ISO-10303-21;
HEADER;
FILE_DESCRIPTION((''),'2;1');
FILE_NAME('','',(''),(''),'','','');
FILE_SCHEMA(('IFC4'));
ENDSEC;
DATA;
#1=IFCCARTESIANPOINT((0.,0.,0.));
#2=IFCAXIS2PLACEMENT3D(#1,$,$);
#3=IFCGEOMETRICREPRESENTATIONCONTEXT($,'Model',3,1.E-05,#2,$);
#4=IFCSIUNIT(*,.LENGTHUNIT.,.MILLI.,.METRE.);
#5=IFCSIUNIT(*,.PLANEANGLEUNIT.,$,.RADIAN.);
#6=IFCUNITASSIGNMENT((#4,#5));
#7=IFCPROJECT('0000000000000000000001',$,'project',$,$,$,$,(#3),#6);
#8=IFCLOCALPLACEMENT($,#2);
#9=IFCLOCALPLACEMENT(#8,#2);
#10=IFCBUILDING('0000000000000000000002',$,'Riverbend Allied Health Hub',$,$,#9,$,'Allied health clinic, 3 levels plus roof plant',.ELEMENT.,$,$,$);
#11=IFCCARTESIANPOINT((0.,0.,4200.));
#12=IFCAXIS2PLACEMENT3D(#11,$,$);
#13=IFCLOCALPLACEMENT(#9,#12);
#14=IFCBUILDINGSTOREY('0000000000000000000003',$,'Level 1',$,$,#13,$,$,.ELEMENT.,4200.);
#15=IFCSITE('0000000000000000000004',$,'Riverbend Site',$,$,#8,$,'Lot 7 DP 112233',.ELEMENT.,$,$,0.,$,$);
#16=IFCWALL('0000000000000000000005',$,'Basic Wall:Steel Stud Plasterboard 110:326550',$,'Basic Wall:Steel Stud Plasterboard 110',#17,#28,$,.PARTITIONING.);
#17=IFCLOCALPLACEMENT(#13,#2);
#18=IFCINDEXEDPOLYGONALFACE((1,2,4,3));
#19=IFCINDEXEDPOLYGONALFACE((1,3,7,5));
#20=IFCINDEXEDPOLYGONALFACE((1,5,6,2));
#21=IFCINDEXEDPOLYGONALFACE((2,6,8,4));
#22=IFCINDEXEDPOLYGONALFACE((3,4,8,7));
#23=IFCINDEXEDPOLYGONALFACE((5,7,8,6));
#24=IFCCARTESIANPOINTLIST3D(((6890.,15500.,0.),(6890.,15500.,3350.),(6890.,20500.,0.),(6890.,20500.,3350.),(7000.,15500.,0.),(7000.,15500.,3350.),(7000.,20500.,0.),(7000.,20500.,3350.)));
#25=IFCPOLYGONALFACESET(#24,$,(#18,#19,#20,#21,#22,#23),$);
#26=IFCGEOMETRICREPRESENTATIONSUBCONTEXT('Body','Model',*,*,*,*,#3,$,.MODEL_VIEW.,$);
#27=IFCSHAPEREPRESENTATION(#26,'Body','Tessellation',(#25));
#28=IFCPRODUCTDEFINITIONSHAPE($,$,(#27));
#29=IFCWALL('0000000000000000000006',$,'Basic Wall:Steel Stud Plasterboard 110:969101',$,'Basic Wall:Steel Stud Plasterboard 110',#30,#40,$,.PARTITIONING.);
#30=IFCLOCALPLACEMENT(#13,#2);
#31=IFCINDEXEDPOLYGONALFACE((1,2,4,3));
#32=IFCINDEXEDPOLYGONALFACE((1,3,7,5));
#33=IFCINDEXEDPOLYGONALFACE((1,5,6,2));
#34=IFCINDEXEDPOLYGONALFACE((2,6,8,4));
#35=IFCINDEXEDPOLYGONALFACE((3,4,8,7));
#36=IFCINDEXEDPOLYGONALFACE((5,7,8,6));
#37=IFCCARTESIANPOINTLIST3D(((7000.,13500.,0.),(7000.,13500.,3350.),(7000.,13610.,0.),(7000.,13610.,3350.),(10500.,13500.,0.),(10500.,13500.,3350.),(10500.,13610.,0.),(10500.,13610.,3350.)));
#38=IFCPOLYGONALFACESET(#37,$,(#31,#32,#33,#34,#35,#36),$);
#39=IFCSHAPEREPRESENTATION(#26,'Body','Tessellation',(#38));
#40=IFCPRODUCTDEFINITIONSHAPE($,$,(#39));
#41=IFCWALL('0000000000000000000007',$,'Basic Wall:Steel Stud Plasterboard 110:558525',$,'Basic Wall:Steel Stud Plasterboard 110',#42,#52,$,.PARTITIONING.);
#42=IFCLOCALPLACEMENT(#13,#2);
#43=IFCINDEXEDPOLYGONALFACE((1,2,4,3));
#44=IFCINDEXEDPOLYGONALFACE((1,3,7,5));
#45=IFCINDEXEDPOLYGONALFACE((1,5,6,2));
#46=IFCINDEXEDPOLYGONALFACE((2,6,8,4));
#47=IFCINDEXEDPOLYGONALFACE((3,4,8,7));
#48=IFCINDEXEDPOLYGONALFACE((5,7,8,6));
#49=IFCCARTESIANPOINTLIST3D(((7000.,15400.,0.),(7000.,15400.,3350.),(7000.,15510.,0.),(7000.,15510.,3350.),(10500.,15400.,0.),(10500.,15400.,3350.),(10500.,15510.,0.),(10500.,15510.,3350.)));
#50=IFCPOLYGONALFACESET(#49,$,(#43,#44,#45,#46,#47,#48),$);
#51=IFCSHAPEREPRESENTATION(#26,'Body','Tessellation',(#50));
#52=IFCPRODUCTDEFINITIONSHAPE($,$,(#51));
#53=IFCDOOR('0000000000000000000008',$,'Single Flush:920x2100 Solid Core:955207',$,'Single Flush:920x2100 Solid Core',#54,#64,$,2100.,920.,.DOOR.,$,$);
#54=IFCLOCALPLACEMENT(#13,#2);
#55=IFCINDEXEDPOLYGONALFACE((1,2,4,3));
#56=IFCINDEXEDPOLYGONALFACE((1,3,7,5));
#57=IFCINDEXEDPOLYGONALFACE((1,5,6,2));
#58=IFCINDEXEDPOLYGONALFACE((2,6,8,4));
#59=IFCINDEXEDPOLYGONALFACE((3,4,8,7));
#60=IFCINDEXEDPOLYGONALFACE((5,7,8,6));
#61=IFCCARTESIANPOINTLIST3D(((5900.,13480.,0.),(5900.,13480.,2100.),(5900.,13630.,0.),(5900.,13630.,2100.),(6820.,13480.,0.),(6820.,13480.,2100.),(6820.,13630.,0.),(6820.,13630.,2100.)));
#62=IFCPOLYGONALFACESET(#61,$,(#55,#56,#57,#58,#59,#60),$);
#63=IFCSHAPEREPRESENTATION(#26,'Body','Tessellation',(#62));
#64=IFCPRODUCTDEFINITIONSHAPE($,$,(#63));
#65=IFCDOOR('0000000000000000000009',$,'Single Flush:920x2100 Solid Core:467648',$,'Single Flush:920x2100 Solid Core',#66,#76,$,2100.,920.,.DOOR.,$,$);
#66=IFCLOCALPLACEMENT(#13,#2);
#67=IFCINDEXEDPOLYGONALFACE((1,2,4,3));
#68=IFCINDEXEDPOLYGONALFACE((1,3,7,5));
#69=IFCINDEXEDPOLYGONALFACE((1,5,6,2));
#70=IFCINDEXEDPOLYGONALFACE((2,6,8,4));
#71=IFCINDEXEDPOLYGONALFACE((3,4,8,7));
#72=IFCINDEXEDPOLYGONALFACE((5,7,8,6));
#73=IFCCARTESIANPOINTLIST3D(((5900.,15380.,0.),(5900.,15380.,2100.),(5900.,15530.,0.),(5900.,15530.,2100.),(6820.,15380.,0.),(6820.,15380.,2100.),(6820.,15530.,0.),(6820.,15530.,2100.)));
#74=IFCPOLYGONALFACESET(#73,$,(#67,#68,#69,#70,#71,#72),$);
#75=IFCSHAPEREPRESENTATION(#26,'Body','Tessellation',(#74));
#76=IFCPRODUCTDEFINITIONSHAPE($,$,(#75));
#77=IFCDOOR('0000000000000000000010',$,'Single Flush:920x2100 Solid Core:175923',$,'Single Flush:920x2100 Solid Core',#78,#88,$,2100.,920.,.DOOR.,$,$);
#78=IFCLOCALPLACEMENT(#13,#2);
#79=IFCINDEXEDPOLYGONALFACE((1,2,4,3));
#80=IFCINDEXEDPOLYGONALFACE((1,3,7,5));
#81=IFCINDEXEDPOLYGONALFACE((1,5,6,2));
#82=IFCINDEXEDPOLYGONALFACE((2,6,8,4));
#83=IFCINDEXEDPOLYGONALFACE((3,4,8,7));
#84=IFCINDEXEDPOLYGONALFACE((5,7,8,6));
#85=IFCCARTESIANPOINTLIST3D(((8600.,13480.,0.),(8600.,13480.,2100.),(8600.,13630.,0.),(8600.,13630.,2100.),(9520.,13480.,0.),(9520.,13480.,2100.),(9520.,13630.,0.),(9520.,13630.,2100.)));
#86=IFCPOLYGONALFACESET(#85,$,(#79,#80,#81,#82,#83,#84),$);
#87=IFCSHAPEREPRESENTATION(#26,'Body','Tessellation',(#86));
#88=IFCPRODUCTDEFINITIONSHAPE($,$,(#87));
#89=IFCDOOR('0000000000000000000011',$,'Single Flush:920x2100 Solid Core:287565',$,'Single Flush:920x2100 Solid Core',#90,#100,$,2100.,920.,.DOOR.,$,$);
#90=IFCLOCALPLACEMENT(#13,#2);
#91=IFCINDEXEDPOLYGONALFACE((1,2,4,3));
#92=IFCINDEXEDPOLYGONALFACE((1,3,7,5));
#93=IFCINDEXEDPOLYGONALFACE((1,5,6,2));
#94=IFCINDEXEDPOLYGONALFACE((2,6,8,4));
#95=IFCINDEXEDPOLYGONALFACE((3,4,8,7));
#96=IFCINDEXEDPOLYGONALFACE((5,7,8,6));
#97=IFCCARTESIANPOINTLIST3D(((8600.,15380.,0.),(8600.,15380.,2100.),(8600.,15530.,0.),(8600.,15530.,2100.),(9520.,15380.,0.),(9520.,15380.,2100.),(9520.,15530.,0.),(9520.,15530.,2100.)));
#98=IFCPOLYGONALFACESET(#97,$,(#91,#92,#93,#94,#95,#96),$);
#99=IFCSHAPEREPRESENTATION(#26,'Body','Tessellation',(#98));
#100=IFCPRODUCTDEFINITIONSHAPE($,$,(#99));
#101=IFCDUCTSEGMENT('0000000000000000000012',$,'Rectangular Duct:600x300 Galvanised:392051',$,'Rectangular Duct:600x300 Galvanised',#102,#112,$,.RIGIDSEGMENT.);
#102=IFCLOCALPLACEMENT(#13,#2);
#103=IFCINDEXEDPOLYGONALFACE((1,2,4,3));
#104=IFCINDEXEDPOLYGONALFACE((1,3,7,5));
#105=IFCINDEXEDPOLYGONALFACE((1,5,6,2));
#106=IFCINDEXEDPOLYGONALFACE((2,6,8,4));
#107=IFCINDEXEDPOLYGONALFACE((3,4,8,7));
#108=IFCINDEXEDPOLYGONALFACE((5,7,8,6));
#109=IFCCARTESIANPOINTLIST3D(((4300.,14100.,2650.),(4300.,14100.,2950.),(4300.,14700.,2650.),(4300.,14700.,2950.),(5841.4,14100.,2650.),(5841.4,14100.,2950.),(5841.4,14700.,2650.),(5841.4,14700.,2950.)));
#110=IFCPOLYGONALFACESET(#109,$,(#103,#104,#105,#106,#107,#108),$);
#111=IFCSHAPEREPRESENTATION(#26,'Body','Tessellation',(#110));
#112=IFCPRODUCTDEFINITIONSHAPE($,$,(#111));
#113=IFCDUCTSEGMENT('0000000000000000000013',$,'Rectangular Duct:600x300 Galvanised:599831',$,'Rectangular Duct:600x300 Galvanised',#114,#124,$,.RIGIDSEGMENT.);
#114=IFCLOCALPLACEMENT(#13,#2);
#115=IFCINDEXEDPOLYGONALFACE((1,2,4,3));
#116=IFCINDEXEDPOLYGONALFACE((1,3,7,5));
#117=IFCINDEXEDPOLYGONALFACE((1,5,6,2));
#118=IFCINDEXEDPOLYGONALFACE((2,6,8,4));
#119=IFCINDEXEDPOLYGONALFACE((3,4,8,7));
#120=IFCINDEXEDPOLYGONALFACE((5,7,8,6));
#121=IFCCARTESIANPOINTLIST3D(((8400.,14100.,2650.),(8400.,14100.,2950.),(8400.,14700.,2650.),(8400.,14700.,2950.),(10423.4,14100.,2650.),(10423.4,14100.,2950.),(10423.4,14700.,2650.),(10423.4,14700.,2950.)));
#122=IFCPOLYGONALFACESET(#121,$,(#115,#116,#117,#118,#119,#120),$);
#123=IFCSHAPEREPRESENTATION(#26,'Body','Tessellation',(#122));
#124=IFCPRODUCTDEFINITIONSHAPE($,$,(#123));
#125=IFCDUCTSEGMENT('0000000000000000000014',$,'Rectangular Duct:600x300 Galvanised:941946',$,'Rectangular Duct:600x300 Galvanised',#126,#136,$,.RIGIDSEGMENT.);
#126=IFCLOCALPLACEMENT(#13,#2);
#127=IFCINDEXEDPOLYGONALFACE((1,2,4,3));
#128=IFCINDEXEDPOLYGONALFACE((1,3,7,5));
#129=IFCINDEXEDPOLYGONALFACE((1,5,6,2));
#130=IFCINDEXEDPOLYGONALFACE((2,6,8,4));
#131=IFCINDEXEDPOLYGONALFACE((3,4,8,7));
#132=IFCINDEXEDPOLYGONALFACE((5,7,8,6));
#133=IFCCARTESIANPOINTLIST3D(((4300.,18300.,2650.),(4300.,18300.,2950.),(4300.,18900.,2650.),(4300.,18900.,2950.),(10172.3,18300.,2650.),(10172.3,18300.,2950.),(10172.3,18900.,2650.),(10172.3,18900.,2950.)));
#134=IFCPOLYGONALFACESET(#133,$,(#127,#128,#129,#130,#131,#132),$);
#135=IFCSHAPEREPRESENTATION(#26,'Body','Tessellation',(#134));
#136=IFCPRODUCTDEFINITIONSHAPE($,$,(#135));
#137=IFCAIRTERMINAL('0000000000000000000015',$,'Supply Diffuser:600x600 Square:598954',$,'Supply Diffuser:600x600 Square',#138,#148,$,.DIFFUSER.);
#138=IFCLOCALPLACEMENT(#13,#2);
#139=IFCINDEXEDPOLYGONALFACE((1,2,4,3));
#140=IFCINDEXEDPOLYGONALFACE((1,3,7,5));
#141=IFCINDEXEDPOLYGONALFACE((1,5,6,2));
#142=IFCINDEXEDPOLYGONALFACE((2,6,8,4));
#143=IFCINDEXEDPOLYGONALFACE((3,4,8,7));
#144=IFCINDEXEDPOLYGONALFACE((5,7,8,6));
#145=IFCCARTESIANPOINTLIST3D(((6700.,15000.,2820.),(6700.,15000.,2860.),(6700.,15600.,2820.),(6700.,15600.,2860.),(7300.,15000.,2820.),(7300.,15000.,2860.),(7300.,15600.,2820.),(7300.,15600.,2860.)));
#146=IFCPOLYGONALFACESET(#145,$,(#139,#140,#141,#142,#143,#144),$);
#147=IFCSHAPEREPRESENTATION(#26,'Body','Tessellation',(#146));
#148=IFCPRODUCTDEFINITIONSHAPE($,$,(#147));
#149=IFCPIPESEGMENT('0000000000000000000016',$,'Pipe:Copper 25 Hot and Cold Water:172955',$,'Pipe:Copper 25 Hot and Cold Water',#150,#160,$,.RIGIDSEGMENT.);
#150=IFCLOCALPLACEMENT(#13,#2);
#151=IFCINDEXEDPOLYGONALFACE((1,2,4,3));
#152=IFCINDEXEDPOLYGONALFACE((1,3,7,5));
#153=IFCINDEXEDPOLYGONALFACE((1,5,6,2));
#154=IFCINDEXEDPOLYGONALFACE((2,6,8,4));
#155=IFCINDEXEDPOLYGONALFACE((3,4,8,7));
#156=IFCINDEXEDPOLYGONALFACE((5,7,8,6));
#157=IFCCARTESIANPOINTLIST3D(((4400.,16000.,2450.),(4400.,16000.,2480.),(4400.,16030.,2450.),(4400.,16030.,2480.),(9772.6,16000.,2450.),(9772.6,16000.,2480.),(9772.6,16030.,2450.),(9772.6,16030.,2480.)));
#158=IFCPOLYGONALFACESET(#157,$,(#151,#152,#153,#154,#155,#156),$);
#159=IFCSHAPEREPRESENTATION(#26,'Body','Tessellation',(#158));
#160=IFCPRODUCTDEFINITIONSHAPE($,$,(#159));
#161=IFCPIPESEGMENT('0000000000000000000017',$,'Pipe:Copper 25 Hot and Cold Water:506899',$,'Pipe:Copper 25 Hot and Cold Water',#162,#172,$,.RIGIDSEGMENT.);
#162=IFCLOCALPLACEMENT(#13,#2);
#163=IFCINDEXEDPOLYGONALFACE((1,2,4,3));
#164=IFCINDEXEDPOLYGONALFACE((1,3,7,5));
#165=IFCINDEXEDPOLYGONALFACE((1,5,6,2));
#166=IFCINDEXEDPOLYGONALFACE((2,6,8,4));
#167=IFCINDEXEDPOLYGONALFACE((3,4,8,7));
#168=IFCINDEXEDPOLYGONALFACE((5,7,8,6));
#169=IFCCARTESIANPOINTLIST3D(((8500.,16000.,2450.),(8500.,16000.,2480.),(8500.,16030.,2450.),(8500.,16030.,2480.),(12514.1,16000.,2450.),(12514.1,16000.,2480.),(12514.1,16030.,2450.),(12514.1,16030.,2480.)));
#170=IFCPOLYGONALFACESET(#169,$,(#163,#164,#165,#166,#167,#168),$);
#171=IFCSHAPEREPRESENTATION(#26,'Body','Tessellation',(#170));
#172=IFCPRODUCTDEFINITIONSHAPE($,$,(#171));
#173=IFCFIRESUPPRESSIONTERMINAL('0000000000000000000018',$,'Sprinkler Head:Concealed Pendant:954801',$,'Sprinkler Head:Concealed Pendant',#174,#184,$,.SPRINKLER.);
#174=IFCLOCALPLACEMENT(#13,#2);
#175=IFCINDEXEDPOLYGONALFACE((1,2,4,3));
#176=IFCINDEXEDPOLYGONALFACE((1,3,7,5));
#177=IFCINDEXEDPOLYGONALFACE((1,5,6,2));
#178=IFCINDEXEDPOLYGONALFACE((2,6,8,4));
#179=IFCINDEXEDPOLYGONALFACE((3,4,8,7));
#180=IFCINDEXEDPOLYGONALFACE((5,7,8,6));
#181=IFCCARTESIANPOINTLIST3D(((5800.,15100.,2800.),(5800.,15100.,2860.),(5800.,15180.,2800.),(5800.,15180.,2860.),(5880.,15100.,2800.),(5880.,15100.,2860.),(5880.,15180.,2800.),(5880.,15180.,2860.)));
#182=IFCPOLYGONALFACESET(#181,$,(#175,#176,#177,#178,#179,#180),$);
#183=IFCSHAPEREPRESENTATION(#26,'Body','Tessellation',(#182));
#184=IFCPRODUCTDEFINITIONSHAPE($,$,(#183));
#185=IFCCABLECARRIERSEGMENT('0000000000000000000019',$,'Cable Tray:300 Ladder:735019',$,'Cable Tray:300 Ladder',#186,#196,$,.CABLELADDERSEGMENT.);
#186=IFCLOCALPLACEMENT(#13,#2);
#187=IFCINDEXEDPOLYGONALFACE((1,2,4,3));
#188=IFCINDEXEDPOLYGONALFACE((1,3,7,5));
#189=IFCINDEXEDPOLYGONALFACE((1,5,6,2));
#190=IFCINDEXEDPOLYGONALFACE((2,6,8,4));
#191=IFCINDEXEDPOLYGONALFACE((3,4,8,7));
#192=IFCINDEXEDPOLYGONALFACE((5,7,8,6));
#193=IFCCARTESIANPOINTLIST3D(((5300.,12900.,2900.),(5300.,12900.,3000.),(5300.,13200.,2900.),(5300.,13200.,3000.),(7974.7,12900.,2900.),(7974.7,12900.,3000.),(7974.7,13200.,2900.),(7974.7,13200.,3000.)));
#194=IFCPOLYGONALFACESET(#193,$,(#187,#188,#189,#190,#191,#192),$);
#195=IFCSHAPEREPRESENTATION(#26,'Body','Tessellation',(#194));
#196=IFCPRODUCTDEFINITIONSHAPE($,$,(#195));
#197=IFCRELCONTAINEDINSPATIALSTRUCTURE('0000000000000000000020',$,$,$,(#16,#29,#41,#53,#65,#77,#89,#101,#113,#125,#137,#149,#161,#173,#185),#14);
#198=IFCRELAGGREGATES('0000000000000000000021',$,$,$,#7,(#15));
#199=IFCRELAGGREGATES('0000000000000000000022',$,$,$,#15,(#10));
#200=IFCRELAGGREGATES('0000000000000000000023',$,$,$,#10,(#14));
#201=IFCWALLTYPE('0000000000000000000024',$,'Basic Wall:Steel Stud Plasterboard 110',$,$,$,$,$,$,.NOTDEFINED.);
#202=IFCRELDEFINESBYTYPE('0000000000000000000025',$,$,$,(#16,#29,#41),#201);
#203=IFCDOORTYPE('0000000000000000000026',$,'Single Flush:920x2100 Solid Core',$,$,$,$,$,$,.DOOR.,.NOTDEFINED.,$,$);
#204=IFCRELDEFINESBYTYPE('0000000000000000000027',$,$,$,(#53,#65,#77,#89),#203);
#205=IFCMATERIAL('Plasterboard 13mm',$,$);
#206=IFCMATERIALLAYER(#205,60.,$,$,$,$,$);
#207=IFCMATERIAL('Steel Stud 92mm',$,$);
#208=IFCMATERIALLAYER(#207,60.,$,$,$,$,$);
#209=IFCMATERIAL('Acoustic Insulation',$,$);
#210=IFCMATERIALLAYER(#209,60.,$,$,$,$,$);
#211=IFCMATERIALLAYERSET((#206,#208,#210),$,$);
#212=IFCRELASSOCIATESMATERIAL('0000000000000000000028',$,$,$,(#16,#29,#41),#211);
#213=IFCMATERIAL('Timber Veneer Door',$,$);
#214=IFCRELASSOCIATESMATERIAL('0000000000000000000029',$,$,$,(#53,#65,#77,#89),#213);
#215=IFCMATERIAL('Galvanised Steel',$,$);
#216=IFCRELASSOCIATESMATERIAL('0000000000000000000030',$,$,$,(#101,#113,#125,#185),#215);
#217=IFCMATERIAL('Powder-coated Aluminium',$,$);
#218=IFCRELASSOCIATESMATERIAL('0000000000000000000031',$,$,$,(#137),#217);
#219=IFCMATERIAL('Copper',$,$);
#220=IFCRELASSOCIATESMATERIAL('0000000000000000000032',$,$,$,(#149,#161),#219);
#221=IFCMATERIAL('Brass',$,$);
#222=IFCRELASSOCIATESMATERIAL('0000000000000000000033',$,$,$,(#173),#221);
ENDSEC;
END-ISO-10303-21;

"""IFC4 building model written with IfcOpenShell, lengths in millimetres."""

from ifc_helpers import new_model, si_unit, frame, frame_2d, origin, place, context, subcontext, project, spatial, rectangle, extrude, material, layer, layer_set, layer_usage, type_object, element, save


model = new_model("IFC4")

# Units and contexts
model_context = context("Model", 3, precision=1e-05, world=origin())
body_context = subcontext(model_context, "Body", "Model", "MODEL_VIEW")
ifc_project = project(units=[si_unit("LENGTHUNIT", "METRE", prefix="MILLI"), si_unit("PLANEANGLEUNIT", "RADIAN")], contexts=[model_context])

# Site, building, storey
site_placement = place(None, origin())
site = spatial("IfcSite", under=ifc_project, at=site_placement, Name="Riverbend Site", LongName="Lot 7 DP 112233", CompositionType="ELEMENT", RefElevation=0.0)
building_placement = place(site_placement, origin())
building = spatial("IfcBuilding", under=site, at=building_placement, Name="Riverbend Allied Health Hub", LongName="Allied health clinic, 3 levels plus roof plant", CompositionType="ELEMENT")
storey_placement = place(building_placement, frame((0.0, 0.0, 4200.0)))
storey = spatial("IfcBuildingStorey", under=building, at=storey_placement, Name="Level 1", CompositionType="ELEMENT", Elevation=4200.0)

# Walls
ifc_material_1 = material(Name="Plasterboard 13mm")
ifc_layer_1 = layer(ifc_material_1, 60.0)
ifc_material_2 = material(Name="Steel Stud 92mm")
ifc_layer_2 = layer(ifc_material_2, 60.0)
ifc_material_3 = material(Name="Acoustic Insulation")
ifc_layer_3 = layer(ifc_material_3, 60.0)
ifc_layer_set = layer_set([ifc_layer_1, ifc_layer_2, ifc_layer_3])
ifc_layer_usage = layer_usage(ifc_layer_set, "AXIS2", "POSITIVE", 0.0)
wall_type = type_object("IfcWallType", Name="Basic Wall:Steel Stud Plasterboard 110", PredefinedType="NOTDEFINED")
wall_placement = place(storey_placement, frame((7000.0, 15500.0, 0.0), z_axis=(0.0, 0.0, 1.0), x_axis=(0.0, 1.0, 0.0)))
element("IfcWall", 1, at=wall_placement, inside=storey, type_object=wall_type, material=ifc_layer_usage, Name="Basic Wall:Steel Stud Plasterboard 110:326550", ObjectType="Basic Wall:Steel Stud Plasterboard 110", PredefinedType="PARTITIONING", context=body_context, shape_type="SweptSolid", body=[
    extrude(rectangle(XDim=5000.0, YDim=110.0, at=frame_2d((2500.0, 55.0))), origin(), (0.0, 0.0, 1.0), 3350.0),
])
for number, where, name in (
    (2, (7000.0, 13500.0, 0.0), "Basic Wall:Steel Stud Plasterboard 110:969101"),
    (3, (7000.0, 15400.0, 0.0), "Basic Wall:Steel Stud Plasterboard 110:558525"),
):
    element("IfcWall", number, at=place(storey_placement, frame(where)), inside=storey, type_object=wall_type, material=ifc_layer_usage, Name=name, ObjectType="Basic Wall:Steel Stud Plasterboard 110", PredefinedType="PARTITIONING", context=body_context, shape_type="SweptSolid", body=[
        extrude(rectangle(XDim=3500.0, YDim=110.0, at=frame_2d((1750.0, 55.0))), origin(), (0.0, 0.0, 1.0), 3350.0),
    ])

# Doors
ifc_material_4 = material(Name="Timber Veneer Door")
door_type = type_object("IfcDoorType", Name="Single Flush:920x2100 Solid Core", OperationType="NOTDEFINED", PredefinedType="DOOR")
for number, where, name in (
    (4, (5900.0, 13480.0, 0.0), "Single Flush:920x2100 Solid Core:955207"),
    (5, (5900.0, 15380.0, 0.0), "Single Flush:920x2100 Solid Core:467648"),
    (6, (8600.0, 13480.0, 0.0), "Single Flush:920x2100 Solid Core:175923"),
    (7, (8600.0, 15380.0, 0.0), "Single Flush:920x2100 Solid Core:287565"),
):
    element("IfcDoor", number, at=place(storey_placement, frame(where)), inside=storey, type_object=door_type, material=ifc_material_4, Name=name, ObjectType="Single Flush:920x2100 Solid Core", OverallHeight=2100.0, OverallWidth=920.0, PredefinedType="DOOR", context=body_context, shape_type="SweptSolid", body=[
        extrude(rectangle(XDim=920.0, YDim=150.0, at=frame_2d((460.0, 75.0))), origin(), (0.0, 0.0, 1.0), 2100.0),
    ])

# Duct segments
ifc_material_5 = material(Name="Galvanised Steel")
duct_segment_1_placement = place(storey_placement, frame((4300.0, 14100.0, 2650.0)))
element("IfcDuctSegment", 8, at=duct_segment_1_placement, inside=storey, material=ifc_material_5, Name="Rectangular Duct:600x300 Galvanised:392051", ObjectType="Rectangular Duct:600x300 Galvanised", PredefinedType="RIGIDSEGMENT", context=body_context, shape_type="SweptSolid", body=[
    extrude(rectangle(XDim=1541.4, YDim=600.0, at=frame_2d((770.7, 300.0))), origin(), (0.0, 0.0, 1.0), 300.0),
])
duct_segment_2_placement = place(storey_placement, frame((8400.0, 14100.0, 2650.0)))
element("IfcDuctSegment", 9, at=duct_segment_2_placement, inside=storey, material=ifc_material_5, Name="Rectangular Duct:600x300 Galvanised:599831", ObjectType="Rectangular Duct:600x300 Galvanised", PredefinedType="RIGIDSEGMENT", context=body_context, shape_type="SweptSolid", body=[
    extrude(rectangle(XDim=2023.4, YDim=600.0, at=frame_2d((1011.7, 300.0))), origin(), (0.0, 0.0, 1.0), 300.0),
])
duct_segment_3_placement = place(storey_placement, frame((4300.0, 18300.0, 2650.0)))
element("IfcDuctSegment", 10, at=duct_segment_3_placement, inside=storey, material=ifc_material_5, Name="Rectangular Duct:600x300 Galvanised:941946", ObjectType="Rectangular Duct:600x300 Galvanised", PredefinedType="RIGIDSEGMENT", context=body_context, shape_type="SweptSolid", body=[
    extrude(rectangle(XDim=5872.3, YDim=600.0, at=frame_2d((2936.2, 300.0))), origin(), (0.0, 0.0, 1.0), 300.0),
])

# Air terminal
ifc_material_6 = material(Name="Powder-coated Aluminium")
air_terminal_placement = place(storey_placement, frame((6700.0, 15000.0, 2820.0)))
element("IfcAirTerminal", 11, at=air_terminal_placement, inside=storey, material=ifc_material_6, Name="Supply Diffuser:600x600 Square:598954", ObjectType="Supply Diffuser:600x600 Square", PredefinedType="DIFFUSER", context=body_context, shape_type="SweptSolid", body=[
    extrude(rectangle(XDim=600.0, YDim=600.0, at=frame_2d((300.0, 300.0))), origin(), (0.0, 0.0, 1.0), 40.0),
])

# Pipe segments
ifc_material_7 = material(Name="Copper")
pipe_segment_1_placement = place(storey_placement, frame((4400.0, 16000.0, 2450.0)))
element("IfcPipeSegment", 12, at=pipe_segment_1_placement, inside=storey, material=ifc_material_7, Name="Pipe:Copper 25 Hot and Cold Water:172955", ObjectType="Pipe:Copper 25 Hot and Cold Water", PredefinedType="RIGIDSEGMENT", context=body_context, shape_type="SweptSolid", body=[
    extrude(rectangle(XDim=5372.6, YDim=30.0, at=frame_2d((2686.3, 15.0))), origin(), (0.0, 0.0, 1.0), 30.0),
])
pipe_segment_2_placement = place(storey_placement, frame((8500.0, 16000.0, 2450.0)))
element("IfcPipeSegment", 13, at=pipe_segment_2_placement, inside=storey, material=ifc_material_7, Name="Pipe:Copper 25 Hot and Cold Water:506899", ObjectType="Pipe:Copper 25 Hot and Cold Water", PredefinedType="RIGIDSEGMENT", context=body_context, shape_type="SweptSolid", body=[
    extrude(rectangle(XDim=4014.1, YDim=30.0, at=frame_2d((2007.1, 15.0))), origin(), (0.0, 0.0, 1.0), 30.0),
])

# Fire suppression terminal
ifc_material_8 = material(Name="Brass")
fire_suppression_terminal_placement = place(storey_placement, frame((5800.0, 15100.0, 2800.0)))
element("IfcFireSuppressionTerminal", 14, at=fire_suppression_terminal_placement, inside=storey, material=ifc_material_8, Name="Sprinkler Head:Concealed Pendant:954801", ObjectType="Sprinkler Head:Concealed Pendant", PredefinedType="SPRINKLER", context=body_context, shape_type="SweptSolid", body=[
    extrude(rectangle(XDim=80.0, YDim=80.0, at=frame_2d((40.0, 40.0))), origin(), (0.0, 0.0, 1.0), 60.0),
])

# Cable carrier segment
cable_carrier_segment_1_placement = place(storey_placement, frame((5300.0, 12900.0, 2900.0)))
element("IfcCableCarrierSegment", 15, at=cable_carrier_segment_1_placement, inside=storey, material=ifc_material_5, Name="Cable Tray:300 Ladder:735019", ObjectType="Cable Tray:300 Ladder", PredefinedType="CABLELADDERSEGMENT", context=body_context, shape_type="SweptSolid", body=[
    extrude(rectangle(XDim=2674.7, YDim=300.0, at=frame_2d((1337.4, 150.0))), origin(), (0.0, 0.0, 1.0), 100.0),
])

save(model, "model.ifc")
